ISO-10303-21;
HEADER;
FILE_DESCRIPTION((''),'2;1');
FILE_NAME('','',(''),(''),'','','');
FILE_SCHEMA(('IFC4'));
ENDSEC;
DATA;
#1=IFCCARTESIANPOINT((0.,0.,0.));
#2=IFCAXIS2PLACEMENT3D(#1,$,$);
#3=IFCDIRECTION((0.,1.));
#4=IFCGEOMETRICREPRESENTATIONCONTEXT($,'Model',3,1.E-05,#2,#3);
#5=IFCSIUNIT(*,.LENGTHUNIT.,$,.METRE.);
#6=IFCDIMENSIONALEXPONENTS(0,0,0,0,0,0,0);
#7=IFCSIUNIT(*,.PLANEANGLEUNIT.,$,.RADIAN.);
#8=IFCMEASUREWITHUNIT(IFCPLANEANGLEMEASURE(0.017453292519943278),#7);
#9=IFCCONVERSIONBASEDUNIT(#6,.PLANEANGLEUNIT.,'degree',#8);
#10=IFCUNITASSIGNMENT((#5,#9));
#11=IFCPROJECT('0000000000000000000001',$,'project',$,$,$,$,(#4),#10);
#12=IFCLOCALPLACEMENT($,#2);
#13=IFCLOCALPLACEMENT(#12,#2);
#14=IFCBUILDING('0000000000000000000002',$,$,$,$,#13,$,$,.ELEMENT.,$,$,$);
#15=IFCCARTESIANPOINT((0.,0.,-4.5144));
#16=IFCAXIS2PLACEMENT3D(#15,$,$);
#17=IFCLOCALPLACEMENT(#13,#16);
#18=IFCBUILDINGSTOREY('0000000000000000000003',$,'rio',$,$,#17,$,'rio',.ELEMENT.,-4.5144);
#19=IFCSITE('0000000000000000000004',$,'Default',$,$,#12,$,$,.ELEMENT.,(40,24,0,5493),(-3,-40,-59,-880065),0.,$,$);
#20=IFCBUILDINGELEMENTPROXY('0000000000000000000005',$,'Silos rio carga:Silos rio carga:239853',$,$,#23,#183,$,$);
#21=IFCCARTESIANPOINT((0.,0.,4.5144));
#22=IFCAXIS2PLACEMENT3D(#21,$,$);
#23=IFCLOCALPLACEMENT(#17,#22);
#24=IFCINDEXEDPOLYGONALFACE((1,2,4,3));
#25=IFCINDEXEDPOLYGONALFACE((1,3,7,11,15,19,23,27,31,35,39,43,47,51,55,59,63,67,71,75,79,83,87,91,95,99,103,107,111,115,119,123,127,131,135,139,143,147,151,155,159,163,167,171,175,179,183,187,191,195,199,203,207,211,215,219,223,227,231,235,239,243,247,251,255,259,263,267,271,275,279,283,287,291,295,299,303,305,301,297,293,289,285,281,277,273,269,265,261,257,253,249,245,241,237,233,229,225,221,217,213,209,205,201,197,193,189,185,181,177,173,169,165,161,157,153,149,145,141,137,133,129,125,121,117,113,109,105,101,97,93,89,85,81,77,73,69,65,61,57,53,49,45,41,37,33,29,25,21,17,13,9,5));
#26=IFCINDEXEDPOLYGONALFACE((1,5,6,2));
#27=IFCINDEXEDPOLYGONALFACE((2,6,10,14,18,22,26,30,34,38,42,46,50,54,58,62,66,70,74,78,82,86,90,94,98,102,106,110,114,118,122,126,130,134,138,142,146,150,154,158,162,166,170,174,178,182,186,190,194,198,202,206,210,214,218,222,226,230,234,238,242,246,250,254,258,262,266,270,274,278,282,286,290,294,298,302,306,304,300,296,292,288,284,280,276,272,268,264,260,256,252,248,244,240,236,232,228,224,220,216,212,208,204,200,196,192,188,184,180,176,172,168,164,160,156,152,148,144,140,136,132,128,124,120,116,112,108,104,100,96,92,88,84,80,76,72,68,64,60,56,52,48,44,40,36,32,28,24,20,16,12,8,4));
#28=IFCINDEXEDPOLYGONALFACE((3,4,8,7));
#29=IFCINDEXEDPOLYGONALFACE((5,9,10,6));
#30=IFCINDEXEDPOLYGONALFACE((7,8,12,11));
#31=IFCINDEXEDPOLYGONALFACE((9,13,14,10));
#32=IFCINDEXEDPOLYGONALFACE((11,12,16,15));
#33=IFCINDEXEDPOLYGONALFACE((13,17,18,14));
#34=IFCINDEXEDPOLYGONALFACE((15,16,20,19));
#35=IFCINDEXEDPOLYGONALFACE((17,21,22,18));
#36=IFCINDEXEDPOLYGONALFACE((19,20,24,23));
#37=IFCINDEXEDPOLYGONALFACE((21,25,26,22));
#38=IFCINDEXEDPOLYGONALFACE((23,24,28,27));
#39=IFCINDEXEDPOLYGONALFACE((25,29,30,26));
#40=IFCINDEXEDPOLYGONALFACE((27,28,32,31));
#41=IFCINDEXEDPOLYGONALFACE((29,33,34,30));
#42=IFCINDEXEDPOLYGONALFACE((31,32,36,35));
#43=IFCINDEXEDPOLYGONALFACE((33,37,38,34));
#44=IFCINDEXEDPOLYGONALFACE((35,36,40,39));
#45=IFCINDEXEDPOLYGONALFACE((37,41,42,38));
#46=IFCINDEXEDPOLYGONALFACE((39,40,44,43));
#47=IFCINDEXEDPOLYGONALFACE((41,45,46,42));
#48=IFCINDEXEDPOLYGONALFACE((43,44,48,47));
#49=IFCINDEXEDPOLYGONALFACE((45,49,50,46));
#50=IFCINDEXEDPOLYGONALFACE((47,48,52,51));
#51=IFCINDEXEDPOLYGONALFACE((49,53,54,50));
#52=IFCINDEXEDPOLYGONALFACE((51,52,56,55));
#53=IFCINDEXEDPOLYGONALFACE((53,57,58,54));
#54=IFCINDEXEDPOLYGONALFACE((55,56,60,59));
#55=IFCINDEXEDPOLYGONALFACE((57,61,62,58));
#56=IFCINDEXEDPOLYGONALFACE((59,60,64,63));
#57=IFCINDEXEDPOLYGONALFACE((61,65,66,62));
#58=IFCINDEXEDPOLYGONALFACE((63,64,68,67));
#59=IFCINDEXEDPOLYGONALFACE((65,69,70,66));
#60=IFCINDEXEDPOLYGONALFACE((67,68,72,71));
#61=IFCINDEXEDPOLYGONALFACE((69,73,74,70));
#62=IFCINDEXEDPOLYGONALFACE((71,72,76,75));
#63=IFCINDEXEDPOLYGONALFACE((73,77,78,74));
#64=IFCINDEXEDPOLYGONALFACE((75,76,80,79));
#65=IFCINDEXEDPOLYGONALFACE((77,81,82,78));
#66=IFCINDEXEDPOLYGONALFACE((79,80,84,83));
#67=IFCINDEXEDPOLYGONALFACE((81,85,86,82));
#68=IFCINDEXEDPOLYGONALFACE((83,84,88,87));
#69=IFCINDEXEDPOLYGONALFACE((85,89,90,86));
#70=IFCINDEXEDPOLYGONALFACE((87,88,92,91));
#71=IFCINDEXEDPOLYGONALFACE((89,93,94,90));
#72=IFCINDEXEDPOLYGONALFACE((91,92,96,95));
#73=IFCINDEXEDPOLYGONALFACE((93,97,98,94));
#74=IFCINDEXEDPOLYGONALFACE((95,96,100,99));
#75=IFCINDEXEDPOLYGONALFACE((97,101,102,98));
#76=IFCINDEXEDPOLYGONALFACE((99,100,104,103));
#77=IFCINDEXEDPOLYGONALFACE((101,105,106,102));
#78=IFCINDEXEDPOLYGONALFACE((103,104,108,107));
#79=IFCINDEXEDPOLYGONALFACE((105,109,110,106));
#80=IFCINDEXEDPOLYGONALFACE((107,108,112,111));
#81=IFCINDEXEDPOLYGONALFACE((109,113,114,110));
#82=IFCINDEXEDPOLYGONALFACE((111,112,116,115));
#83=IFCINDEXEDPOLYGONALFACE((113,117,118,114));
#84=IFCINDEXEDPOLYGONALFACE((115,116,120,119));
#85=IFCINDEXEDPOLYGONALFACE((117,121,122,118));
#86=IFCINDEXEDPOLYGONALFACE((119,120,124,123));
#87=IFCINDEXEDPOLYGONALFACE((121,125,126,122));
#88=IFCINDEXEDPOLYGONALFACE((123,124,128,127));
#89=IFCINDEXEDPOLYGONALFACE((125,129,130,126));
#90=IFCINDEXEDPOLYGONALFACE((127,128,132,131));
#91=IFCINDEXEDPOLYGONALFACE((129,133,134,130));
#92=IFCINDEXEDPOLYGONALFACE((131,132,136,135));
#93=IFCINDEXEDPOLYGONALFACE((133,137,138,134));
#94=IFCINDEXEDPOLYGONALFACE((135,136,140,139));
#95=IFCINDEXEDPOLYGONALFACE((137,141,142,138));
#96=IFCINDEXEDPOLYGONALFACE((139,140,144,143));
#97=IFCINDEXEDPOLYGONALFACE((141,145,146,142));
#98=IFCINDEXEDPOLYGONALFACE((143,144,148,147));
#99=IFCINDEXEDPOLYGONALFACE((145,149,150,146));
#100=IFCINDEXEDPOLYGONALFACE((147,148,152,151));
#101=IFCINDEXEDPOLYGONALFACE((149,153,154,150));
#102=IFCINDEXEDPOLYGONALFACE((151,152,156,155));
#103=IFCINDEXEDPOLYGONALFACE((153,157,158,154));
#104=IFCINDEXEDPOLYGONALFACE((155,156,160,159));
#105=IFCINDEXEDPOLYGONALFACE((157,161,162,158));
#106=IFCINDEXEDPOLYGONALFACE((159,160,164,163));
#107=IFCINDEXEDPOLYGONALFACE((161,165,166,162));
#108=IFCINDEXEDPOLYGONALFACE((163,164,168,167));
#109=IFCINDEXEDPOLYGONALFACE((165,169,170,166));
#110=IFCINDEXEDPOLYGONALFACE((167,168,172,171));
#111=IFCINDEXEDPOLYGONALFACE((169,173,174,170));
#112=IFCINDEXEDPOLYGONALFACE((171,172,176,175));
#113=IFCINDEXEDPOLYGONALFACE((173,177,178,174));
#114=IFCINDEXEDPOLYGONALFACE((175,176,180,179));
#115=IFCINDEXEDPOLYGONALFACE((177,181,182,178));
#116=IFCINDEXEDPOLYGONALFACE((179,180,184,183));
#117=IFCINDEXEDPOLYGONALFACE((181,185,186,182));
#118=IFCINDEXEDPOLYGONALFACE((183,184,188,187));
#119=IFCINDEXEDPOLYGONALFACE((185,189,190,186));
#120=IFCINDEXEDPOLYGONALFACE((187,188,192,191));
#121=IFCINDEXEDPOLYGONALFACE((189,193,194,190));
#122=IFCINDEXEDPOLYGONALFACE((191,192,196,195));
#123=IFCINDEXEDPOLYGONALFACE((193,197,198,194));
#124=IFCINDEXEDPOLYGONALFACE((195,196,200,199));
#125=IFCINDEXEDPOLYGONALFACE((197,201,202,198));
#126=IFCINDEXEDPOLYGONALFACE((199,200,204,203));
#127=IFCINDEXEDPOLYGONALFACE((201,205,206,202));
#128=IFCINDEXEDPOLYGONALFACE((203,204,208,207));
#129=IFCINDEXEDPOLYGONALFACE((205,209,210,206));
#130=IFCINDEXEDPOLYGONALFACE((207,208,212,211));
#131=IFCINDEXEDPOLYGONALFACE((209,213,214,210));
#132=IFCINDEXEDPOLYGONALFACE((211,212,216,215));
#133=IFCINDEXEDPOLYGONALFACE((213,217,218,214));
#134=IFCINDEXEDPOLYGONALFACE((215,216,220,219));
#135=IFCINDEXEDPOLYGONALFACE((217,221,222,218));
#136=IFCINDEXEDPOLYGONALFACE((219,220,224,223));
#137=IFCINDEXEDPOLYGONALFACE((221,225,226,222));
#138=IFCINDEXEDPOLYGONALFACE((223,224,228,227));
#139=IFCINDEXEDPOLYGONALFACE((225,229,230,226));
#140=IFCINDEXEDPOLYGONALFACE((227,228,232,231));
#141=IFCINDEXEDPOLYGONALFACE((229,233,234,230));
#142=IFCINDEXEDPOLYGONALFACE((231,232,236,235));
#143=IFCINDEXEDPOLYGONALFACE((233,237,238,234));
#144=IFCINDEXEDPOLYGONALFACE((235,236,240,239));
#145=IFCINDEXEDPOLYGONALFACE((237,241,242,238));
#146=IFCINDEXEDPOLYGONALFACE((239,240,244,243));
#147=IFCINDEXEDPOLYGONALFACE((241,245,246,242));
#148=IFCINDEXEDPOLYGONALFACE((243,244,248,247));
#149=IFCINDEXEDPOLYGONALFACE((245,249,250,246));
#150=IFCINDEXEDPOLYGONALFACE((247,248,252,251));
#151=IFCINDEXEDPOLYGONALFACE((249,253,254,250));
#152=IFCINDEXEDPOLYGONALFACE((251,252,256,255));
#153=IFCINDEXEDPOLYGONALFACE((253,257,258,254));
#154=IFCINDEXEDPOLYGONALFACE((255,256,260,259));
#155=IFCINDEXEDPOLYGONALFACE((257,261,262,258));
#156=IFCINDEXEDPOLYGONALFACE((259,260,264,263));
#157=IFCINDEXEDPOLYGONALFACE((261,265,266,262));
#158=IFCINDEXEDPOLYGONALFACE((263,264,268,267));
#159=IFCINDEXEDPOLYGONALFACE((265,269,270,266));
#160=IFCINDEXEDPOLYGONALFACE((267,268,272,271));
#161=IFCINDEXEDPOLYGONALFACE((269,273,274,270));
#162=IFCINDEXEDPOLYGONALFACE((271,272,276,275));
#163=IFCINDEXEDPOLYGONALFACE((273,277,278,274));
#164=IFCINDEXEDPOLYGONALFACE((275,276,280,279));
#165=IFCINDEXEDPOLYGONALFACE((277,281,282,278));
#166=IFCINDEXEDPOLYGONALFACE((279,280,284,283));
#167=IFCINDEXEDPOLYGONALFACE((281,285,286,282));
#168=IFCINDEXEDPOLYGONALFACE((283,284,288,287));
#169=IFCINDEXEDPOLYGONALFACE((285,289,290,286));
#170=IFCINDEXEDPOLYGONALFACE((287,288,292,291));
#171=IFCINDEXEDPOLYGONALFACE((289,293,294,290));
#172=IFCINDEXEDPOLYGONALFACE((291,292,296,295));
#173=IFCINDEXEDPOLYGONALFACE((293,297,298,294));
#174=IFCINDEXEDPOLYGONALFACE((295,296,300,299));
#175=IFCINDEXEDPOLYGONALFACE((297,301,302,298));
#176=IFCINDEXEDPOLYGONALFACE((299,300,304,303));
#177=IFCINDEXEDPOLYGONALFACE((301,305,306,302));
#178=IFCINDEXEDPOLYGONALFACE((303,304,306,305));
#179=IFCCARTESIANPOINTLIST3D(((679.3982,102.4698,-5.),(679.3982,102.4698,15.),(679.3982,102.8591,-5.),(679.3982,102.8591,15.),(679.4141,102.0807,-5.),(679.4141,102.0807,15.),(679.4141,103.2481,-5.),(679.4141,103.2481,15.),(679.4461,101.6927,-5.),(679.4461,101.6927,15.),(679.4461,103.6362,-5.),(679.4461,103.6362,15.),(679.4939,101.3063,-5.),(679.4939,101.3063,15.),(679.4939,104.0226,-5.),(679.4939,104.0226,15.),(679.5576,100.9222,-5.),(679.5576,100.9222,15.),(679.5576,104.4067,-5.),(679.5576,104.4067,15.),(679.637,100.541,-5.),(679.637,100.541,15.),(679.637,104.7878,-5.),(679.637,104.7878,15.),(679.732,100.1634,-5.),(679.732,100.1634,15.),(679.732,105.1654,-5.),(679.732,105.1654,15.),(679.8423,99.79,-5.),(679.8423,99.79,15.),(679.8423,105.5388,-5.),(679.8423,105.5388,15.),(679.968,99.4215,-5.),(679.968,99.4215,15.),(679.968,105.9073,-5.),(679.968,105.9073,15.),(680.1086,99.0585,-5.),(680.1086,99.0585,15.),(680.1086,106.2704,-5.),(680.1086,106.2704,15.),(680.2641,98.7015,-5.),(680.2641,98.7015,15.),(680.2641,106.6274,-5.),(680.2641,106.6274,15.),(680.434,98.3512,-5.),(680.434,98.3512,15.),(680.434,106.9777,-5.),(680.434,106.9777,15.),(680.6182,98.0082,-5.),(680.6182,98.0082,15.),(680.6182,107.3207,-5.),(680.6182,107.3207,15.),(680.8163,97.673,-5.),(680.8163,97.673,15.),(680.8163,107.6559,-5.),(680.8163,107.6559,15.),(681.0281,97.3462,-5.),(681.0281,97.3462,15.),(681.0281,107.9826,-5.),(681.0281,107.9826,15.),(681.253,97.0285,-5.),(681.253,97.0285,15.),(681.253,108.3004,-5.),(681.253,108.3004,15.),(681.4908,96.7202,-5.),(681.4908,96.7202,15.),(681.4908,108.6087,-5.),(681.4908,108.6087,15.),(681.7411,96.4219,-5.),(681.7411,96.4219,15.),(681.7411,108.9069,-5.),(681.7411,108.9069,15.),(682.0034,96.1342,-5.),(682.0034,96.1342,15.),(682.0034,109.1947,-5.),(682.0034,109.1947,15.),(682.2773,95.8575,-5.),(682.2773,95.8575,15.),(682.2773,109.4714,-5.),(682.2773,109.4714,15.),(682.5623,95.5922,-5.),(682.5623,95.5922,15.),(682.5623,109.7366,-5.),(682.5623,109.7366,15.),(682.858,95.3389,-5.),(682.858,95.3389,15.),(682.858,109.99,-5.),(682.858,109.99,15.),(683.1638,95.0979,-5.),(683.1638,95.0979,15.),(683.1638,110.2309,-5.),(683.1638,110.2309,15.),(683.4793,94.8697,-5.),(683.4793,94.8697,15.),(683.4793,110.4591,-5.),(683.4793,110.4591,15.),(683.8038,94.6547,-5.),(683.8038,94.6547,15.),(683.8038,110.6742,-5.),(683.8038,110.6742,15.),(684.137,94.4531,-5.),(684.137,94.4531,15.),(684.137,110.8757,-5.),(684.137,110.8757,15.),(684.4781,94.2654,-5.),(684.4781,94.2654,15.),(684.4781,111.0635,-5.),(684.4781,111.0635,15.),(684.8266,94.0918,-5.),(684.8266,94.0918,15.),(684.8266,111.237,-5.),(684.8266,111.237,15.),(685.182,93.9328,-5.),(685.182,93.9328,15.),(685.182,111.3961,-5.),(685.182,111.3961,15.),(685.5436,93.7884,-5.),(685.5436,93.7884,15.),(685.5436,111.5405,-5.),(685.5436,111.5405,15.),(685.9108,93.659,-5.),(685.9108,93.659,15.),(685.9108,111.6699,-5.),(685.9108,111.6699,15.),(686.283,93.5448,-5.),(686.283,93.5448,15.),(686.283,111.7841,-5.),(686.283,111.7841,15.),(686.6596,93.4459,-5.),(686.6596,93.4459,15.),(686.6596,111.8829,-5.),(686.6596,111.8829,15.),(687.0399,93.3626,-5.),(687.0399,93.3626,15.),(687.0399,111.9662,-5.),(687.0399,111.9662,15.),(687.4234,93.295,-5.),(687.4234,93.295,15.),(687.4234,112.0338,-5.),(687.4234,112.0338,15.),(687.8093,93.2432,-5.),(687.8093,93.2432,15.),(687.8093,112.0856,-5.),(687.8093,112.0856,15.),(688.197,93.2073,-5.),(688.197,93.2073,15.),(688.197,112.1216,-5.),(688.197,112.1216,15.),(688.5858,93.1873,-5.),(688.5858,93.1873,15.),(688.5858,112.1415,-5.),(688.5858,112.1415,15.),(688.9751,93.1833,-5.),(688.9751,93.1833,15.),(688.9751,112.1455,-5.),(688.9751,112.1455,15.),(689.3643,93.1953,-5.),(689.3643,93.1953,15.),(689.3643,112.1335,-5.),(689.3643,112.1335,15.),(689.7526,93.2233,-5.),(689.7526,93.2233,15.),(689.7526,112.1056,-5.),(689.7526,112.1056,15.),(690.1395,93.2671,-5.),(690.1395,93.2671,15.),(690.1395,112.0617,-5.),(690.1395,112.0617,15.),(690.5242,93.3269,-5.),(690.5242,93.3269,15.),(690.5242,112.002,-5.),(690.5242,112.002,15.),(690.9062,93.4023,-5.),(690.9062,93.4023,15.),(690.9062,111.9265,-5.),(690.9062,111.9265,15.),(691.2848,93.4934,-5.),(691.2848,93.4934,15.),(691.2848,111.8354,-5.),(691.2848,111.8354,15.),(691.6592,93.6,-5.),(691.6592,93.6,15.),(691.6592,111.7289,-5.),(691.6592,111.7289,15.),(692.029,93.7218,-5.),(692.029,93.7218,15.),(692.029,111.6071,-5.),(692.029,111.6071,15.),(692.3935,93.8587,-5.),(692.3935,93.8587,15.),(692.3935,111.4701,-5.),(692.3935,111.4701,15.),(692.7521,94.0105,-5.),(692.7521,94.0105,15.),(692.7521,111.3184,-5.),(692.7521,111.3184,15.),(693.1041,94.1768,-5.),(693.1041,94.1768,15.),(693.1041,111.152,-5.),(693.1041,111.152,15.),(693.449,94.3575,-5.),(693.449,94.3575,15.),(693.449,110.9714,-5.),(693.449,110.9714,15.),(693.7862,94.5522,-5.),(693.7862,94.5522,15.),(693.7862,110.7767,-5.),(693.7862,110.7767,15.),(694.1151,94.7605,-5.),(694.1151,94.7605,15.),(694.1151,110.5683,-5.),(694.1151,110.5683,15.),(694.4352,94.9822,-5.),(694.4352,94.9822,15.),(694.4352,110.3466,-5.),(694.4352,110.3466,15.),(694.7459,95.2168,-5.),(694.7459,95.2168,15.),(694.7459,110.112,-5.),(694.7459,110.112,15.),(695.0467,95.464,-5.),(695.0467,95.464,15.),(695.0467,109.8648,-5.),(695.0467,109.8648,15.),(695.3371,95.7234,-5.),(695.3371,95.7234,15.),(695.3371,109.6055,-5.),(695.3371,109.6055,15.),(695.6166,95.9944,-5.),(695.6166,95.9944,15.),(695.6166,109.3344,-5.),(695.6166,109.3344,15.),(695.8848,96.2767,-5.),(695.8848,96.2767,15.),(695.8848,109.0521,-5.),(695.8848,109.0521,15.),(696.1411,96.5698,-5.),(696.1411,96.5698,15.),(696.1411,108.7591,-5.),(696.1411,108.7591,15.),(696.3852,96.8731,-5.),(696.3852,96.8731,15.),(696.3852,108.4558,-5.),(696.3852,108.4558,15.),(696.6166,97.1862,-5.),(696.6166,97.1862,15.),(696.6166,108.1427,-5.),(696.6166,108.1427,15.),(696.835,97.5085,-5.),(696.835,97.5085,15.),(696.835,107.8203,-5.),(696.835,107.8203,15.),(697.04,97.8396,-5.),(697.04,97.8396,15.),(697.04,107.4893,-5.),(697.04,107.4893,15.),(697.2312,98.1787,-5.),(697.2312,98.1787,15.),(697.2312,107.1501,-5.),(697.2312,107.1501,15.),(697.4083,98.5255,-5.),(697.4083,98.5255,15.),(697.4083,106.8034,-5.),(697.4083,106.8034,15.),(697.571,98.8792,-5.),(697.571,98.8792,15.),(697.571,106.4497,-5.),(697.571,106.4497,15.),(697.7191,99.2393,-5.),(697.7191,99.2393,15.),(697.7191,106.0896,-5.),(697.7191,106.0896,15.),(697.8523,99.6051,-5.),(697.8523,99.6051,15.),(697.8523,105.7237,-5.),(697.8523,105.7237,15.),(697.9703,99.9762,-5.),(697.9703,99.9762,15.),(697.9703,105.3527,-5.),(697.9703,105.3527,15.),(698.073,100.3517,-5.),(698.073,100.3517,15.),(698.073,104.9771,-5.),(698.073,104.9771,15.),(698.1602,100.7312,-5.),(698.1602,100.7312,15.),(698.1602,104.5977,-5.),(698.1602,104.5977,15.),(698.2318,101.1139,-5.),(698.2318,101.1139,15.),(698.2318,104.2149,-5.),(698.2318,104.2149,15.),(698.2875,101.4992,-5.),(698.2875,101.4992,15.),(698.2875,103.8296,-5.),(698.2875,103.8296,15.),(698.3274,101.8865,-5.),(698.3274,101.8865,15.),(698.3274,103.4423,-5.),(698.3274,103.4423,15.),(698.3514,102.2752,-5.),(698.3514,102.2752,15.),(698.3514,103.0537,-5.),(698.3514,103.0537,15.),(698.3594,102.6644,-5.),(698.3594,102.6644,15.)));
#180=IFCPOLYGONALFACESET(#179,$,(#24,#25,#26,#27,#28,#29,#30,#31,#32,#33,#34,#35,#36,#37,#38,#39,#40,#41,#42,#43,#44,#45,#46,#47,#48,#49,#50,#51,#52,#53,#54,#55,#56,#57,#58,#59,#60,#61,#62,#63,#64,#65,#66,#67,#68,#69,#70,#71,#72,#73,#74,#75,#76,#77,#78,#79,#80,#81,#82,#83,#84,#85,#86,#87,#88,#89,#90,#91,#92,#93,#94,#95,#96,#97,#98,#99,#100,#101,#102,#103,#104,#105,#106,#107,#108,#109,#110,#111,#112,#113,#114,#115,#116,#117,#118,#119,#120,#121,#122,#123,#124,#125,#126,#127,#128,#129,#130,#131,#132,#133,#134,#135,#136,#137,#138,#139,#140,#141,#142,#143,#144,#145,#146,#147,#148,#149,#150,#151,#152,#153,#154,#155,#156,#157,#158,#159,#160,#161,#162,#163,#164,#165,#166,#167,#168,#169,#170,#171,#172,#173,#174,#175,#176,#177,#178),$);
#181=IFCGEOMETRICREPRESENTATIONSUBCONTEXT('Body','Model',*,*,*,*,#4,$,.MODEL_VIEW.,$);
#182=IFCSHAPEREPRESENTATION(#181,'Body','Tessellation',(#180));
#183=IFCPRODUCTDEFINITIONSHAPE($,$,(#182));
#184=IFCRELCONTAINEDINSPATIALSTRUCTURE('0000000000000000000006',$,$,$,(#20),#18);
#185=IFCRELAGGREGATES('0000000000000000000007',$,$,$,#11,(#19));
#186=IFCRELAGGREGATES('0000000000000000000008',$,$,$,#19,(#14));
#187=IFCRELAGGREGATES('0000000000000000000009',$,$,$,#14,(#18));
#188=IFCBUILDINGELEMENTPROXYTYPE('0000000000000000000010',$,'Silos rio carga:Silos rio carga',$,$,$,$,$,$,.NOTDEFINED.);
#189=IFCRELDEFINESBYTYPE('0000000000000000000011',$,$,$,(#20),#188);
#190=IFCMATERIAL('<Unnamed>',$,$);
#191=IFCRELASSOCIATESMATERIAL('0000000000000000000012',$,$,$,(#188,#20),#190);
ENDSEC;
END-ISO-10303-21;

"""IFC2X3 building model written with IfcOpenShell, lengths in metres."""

from ifc_helpers import new_model, entity, si_unit, converted_unit, direction, frame, frame_2d, origin, place, context, subcontext, project, spatial, circle, extrude, source, transform, mapped, material, type_object, type_shapes, element, save


model = new_model("IFC2X3")

# Units and contexts
model_context = context("Model", 3, precision=1e-05, world=origin(), true_north=direction((0.0, 1.0)))
body_context = subcontext(model_context, "Body", "Model", "MODEL_VIEW")
ifc_project = project(units=[si_unit("LENGTHUNIT", "METRE"), converted_unit("PLANEANGLEUNIT", "degree", entity("IfcPlaneAngleMeasure", 0.017453292519943278), si_unit("PLANEANGLEUNIT", "RADIAN"), dimensions=[0, 0, 0, 0, 0, 0, 0])], contexts=[model_context])

# Site, building, storey
site_placement = place(None, origin())
site = spatial("IfcSite", under=ifc_project, at=site_placement, Name="Default", CompositionType="ELEMENT", RefLatitude=(40, 24, 0, 5493), RefLongitude=(-3, -40, -59, -880065), RefElevation=0.0)
building_placement = place(site_placement, origin())
building = spatial("IfcBuilding", under=site, at=building_placement, CompositionType="ELEMENT")
storey_placement = place(building_placement, frame((0.0, 0.0, -4.5144)))
storey = spatial("IfcBuildingStorey", under=building, at=storey_placement, Name="rio", LongName="rio", CompositionType="ELEMENT", Elevation=-4.5144)

# Building element proxy
ifc_material_1 = material(Name="<Unnamed>")
building_element_proxy_type_1 = type_object("IfcBuildingElementProxyType", Name="Silos rio carga:Silos rio carga", PredefinedType="NOTDEFINED", material=ifc_material_1)
shared_shape_1 = source(origin(), body_context, "Body", "SweptSolid", [
    extrude(circle(Radius=9.4816, at=frame_2d((0.0, 0.0), x_axis=(1.0, 0.0))), frame((688.8778, 102.6644, -5.0)), (0.0, 0.0, 1.0), 20.0),
])
type_shapes(building_element_proxy_type_1, [shared_shape_1])
proxy_1_placement = place(storey_placement, frame((0.0, 0.0, 4.5144)))
element("IfcBuildingElementProxy", 1, at=proxy_1_placement, inside=storey, type_object=building_element_proxy_type_1, material=ifc_material_1, Name="Silos rio carga:Silos rio carga:239853", context=body_context, shape_type="MappedRepresentation", body=[
    mapped(shared_shape_1, transform((0.0, 0.0, 0.0), scale=1.0)),
])

save(model, "model.ifc")
